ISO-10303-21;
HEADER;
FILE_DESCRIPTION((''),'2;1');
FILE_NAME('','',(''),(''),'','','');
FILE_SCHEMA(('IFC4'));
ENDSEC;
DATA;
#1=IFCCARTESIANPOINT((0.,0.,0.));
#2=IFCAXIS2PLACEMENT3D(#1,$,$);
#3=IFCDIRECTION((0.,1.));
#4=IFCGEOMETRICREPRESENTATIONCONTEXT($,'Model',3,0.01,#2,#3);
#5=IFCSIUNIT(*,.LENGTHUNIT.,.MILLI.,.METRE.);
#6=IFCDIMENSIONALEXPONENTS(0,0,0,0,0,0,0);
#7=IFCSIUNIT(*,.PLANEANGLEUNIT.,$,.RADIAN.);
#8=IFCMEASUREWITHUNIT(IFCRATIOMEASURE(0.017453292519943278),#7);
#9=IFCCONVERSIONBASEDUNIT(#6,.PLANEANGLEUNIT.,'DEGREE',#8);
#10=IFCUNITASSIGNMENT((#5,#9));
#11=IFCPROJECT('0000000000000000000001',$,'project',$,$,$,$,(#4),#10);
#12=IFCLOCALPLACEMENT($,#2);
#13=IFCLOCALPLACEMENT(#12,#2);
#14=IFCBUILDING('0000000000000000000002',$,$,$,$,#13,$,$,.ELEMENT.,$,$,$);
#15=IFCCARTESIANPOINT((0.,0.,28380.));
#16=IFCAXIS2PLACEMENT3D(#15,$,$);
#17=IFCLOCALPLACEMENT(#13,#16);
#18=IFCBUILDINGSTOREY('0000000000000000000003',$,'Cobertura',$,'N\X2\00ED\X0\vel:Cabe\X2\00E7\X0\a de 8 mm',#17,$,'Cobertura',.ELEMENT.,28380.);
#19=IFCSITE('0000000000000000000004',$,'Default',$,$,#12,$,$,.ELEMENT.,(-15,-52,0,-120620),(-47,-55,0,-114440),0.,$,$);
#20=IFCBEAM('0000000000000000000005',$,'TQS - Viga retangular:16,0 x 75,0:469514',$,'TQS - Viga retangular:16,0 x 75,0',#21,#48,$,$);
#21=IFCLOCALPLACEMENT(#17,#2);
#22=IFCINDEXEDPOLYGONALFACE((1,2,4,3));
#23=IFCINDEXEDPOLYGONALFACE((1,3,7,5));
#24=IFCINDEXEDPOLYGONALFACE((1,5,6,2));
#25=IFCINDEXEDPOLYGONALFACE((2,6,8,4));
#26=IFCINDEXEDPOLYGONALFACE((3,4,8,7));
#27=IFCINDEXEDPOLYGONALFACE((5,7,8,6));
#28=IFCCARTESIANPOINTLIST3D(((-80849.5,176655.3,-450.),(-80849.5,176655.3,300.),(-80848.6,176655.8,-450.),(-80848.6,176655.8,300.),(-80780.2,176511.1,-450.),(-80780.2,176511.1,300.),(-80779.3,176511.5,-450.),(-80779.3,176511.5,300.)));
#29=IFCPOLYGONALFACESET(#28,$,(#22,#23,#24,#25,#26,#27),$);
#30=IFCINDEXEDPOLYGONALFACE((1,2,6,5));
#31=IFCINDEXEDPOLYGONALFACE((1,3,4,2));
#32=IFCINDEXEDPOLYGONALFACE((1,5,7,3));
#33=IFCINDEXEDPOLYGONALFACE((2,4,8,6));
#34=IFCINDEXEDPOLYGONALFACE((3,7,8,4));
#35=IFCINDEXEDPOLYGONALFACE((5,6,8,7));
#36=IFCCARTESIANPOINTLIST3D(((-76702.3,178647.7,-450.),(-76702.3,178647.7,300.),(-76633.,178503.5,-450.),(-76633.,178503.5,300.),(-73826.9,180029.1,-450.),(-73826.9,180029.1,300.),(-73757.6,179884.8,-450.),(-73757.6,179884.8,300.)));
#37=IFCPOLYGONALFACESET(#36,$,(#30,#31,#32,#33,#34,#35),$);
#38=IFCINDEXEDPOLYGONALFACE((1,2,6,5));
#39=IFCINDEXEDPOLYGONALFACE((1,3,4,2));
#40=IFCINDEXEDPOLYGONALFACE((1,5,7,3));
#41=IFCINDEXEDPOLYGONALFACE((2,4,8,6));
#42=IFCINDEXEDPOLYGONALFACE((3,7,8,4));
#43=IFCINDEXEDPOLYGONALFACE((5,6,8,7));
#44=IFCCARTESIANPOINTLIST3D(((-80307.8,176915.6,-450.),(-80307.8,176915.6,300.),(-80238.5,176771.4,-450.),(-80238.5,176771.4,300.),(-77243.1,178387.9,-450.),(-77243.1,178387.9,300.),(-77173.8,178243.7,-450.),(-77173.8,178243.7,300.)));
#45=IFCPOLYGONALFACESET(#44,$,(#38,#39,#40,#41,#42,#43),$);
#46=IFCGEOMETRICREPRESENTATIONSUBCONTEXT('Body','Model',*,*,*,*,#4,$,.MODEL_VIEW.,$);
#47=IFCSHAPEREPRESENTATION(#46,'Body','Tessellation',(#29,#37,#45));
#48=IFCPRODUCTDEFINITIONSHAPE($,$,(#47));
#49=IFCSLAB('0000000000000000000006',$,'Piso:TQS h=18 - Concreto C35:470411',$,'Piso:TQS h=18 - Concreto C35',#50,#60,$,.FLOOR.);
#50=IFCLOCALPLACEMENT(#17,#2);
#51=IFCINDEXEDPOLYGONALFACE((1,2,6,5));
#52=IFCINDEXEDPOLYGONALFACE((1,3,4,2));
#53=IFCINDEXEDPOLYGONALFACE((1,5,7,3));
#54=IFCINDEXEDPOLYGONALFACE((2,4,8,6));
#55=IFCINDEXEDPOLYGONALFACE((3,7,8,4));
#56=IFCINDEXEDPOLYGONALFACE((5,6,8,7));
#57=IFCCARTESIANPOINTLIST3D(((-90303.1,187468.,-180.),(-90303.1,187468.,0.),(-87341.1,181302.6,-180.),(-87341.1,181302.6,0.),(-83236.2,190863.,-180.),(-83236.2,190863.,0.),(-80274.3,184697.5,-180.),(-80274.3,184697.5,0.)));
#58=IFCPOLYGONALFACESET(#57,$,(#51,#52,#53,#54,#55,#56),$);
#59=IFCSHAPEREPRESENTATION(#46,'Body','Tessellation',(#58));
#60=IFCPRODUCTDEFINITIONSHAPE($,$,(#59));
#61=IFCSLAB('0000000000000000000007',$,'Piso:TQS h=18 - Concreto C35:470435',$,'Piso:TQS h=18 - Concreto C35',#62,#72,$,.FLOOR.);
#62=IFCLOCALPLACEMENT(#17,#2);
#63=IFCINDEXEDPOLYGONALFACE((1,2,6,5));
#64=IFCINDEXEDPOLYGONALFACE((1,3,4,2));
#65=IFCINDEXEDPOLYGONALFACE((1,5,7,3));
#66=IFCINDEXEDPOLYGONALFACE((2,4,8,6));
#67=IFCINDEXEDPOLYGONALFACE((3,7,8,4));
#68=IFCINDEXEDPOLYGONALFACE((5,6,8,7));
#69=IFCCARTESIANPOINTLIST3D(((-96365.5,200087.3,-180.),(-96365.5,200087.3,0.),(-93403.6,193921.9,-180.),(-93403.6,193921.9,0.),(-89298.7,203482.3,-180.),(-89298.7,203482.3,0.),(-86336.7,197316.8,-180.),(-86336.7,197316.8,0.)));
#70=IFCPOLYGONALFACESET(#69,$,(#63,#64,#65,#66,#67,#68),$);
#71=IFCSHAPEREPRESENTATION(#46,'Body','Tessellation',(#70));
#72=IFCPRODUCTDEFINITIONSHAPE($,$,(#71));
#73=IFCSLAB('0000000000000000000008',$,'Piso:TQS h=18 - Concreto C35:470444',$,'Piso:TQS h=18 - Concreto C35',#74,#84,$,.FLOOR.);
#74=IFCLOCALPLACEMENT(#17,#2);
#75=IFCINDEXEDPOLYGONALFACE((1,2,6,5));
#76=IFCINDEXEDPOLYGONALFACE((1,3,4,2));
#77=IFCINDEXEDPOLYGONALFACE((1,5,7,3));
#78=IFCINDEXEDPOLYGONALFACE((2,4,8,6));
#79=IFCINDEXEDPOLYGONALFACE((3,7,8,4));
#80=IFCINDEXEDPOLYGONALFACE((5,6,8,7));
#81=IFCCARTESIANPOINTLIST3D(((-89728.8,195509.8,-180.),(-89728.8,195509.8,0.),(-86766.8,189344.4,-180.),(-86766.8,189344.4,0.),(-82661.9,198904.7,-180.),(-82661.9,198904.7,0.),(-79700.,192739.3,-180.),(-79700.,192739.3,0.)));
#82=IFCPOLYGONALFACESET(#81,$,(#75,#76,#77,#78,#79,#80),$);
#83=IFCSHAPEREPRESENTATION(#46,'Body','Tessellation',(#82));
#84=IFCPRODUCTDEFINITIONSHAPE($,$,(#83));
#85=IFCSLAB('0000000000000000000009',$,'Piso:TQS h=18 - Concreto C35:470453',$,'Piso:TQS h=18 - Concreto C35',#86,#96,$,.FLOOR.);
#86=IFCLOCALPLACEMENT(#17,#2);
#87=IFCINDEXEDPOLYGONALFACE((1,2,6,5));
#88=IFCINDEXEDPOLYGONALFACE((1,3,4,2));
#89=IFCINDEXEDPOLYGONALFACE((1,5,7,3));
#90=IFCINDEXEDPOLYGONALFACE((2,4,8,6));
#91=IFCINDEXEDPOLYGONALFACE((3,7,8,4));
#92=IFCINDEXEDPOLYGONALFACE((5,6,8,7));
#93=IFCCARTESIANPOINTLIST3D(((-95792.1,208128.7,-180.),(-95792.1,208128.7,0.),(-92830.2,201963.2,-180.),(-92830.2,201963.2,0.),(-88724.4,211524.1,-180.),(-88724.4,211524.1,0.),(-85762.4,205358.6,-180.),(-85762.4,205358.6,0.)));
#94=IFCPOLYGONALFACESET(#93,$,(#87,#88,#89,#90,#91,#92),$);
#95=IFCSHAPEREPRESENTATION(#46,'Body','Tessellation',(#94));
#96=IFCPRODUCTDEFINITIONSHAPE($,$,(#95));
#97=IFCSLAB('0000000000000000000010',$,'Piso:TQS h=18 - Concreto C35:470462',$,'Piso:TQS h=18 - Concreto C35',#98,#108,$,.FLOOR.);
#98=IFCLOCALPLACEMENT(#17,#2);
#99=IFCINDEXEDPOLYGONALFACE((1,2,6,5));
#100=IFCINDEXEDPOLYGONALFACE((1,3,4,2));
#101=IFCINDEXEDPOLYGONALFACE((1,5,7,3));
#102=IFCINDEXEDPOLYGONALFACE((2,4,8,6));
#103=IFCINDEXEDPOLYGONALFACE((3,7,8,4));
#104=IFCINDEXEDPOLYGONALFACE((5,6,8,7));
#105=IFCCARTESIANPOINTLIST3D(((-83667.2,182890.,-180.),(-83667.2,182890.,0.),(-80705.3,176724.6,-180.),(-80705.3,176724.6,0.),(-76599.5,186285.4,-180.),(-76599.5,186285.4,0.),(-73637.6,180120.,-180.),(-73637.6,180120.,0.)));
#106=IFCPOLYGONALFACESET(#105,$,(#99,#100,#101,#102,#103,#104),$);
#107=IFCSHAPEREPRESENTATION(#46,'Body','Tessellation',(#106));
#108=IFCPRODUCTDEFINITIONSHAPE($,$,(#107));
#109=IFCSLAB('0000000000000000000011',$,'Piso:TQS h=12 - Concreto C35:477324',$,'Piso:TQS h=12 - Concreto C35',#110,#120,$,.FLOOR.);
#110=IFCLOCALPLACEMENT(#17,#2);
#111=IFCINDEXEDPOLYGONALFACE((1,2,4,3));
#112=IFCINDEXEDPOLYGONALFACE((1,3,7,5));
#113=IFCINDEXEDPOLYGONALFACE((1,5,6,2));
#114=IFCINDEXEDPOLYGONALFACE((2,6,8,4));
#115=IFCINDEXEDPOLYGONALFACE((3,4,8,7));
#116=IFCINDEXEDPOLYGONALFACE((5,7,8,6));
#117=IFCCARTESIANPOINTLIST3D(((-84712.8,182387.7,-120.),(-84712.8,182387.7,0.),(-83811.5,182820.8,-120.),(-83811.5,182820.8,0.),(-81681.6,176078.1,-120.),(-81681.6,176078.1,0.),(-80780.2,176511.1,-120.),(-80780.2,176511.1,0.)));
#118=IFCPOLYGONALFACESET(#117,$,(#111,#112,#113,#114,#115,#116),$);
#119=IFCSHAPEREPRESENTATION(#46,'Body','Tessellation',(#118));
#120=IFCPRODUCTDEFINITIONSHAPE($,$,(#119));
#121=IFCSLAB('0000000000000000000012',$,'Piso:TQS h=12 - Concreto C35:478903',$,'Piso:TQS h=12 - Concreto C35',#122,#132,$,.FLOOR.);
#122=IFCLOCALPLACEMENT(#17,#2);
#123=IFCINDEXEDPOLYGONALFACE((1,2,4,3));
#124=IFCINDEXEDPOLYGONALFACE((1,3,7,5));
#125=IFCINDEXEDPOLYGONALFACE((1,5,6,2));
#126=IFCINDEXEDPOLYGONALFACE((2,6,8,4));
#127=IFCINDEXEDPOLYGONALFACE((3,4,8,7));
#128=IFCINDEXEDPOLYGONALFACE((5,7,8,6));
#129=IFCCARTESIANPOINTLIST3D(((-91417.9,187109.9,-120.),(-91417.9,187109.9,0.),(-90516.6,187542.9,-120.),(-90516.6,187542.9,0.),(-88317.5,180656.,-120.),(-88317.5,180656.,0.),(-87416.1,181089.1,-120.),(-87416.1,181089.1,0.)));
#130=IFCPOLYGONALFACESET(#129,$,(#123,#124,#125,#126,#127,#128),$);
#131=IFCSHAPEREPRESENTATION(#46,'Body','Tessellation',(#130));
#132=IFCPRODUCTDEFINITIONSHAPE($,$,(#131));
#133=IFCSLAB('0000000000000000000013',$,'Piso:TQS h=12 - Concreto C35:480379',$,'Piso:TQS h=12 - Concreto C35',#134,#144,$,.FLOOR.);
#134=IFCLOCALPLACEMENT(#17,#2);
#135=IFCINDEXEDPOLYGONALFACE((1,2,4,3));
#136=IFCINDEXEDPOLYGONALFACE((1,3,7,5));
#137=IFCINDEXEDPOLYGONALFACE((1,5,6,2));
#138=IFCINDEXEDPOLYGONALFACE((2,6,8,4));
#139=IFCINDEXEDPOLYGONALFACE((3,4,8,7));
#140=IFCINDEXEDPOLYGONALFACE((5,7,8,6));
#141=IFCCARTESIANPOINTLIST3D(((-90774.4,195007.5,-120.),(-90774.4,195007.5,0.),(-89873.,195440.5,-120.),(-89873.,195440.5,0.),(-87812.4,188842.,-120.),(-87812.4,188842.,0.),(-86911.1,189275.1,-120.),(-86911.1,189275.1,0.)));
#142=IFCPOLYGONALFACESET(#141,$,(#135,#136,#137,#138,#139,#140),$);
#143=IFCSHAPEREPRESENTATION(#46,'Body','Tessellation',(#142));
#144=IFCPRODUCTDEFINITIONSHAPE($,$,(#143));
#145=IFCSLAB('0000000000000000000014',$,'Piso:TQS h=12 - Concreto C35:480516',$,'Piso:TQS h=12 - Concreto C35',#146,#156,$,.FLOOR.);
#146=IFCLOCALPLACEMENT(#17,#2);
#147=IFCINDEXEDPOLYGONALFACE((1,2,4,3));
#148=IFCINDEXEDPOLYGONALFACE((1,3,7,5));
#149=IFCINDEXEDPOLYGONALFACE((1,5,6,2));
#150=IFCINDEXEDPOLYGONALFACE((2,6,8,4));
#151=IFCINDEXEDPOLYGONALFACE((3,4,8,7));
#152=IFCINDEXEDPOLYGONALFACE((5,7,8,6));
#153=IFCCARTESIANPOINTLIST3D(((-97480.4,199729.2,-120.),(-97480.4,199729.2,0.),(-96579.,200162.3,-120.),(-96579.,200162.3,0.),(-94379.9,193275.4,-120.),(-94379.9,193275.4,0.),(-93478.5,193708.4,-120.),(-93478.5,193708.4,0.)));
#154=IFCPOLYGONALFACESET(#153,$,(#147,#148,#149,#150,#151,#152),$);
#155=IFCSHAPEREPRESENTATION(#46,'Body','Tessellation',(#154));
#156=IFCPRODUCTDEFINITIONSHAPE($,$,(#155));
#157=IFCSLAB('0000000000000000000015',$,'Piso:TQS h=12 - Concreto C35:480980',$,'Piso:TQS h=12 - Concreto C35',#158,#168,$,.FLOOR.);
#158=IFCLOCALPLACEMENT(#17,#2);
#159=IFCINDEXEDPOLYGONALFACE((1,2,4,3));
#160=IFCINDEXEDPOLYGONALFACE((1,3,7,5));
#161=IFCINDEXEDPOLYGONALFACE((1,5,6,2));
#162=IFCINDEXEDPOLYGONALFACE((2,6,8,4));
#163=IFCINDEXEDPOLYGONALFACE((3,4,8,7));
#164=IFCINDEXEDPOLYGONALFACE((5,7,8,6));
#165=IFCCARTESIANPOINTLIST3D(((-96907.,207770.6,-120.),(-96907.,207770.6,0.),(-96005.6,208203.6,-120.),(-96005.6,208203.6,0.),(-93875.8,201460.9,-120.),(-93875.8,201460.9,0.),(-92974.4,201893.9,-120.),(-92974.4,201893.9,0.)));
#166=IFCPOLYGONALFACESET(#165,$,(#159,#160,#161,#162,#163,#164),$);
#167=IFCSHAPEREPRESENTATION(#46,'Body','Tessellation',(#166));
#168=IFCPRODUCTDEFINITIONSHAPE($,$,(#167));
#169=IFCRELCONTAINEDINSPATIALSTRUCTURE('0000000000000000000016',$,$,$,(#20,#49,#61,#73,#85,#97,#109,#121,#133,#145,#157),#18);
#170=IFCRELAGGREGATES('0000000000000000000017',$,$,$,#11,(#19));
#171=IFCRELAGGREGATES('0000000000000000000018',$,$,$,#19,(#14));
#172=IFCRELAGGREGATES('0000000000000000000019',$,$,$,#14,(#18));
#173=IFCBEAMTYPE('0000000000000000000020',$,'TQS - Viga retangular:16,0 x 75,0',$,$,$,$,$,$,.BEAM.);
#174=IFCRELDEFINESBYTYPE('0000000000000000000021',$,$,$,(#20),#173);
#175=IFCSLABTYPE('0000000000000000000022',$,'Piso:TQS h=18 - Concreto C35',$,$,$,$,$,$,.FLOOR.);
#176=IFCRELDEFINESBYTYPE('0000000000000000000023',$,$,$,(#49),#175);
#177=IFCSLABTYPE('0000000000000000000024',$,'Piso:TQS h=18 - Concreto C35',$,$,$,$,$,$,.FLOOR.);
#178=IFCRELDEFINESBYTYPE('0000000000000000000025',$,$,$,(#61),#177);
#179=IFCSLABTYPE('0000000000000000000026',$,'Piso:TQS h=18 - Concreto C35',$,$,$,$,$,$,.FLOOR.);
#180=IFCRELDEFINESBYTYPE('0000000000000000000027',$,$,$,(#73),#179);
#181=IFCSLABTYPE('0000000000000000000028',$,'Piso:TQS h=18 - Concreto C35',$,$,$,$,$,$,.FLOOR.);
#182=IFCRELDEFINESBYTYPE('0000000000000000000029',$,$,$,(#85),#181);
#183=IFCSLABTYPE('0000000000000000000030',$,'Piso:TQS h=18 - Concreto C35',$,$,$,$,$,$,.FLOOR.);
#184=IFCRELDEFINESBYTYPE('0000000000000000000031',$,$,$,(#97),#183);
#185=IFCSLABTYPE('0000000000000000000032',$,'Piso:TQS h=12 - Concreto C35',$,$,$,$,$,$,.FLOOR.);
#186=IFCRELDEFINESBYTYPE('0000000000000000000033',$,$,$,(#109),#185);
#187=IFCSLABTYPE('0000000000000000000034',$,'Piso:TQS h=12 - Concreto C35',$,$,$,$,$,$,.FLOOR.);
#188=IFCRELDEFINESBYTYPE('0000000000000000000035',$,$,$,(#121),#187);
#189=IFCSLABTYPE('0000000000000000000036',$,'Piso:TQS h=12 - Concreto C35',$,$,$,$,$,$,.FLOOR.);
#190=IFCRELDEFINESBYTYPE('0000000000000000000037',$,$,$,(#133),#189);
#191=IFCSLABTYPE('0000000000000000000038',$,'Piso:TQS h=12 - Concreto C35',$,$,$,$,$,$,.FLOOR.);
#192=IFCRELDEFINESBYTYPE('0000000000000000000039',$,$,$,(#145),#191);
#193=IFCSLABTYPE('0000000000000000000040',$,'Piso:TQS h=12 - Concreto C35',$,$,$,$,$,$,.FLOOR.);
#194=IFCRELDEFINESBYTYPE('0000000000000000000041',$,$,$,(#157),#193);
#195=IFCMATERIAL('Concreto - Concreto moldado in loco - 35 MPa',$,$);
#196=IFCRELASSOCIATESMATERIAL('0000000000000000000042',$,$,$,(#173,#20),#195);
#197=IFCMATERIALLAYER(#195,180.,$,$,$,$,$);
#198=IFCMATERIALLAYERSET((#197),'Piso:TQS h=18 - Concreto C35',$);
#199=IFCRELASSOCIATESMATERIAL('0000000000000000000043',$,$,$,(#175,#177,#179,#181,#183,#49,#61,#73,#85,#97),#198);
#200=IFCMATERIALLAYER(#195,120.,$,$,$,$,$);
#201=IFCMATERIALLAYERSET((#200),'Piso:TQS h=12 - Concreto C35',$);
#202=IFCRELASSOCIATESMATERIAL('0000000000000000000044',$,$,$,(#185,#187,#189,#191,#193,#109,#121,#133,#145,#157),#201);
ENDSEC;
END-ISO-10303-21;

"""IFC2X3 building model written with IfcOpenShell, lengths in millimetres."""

from ifc_helpers import new_model, entity, si_unit, converted_unit, direction, frame, frame_2d, origin, place, context, subcontext, project, spatial, rectangle, extrude, source, transform, mapped, material, layer, layer_set, layer_usage, type_object, type_shapes, element, save


model = new_model("IFC2X3")

# Units and contexts
model_context = context("Model", 3, precision=0.01, world=origin(), true_north=direction((0.0, 1.0)))
body_context = subcontext(model_context, "Body", "Model", "MODEL_VIEW")
ifc_project = project(units=[si_unit("LENGTHUNIT", "METRE", prefix="MILLI"), converted_unit("PLANEANGLEUNIT", "DEGREE", entity("IfcRatioMeasure", 0.017453292519943278), si_unit("PLANEANGLEUNIT", "RADIAN"), dimensions=[0, 0, 0, 0, 0, 0, 0])], contexts=[model_context])

# Site, building, storey
site_placement = place(None, origin())
site = spatial("IfcSite", under=ifc_project, at=site_placement, Name="Default", CompositionType="ELEMENT", RefLatitude=(-15, -52, 0, -120620), RefLongitude=(-47, -55, 0, -114440), RefElevation=0.0)
building_placement = place(site_placement, origin())
building = spatial("IfcBuilding", under=site, at=building_placement, CompositionType="ELEMENT")
storey_placement = place(building_placement, frame((0.0, 0.0, 28380.0)))
storey = spatial("IfcBuildingStorey", under=building, at=storey_placement, Name="Cobertura", ObjectType="Nível:Cabeça de 8 mm", LongName="Cobertura", CompositionType="ELEMENT", Elevation=28380.0)

# Beam
ifc_material = material(Name="Concreto - Concreto moldado in loco - 35 MPa")
beam_type_1 = type_object("IfcBeamType", Name="TQS - Viga retangular:16,0 x 75,0", PredefinedType="BEAM", material=ifc_material)
shared_shape_1 = source(origin(), body_context, "Body", "SweptSolid", [
    extrude(rectangle(XDim=750.0, YDim=160.0, at=frame_2d((0.0, 0.0), x_axis=(1.0, 0.0))), frame((-80814.0, 176583.6, 28305.0), z_axis=(-0.90138, -0.43303, 0.0), x_axis=(0.0, 0.0, -1.0)), (0.0, 0.0, 1.0), 1.0),
    extrude(rectangle(XDim=750.0, YDim=160.0, at=frame_2d((0.0, 0.0), x_axis=(1.0, 0.0))), frame((-73792.2, 179956.9, 28305.0), z_axis=(-0.90138, -0.43303, 0.0), x_axis=(0.0, 0.0, -1.0)), (0.0, 0.0, 1.0), 3190.0),
    extrude(rectangle(XDim=750.0, YDim=160.0, at=frame_2d((0.0, 0.0), x_axis=(1.0, 0.0))), frame((-77208.5, 178315.8, 28305.0), z_axis=(-0.90138, -0.43303, 0.0), x_axis=(0.0, 0.0, -1.0)), (0.0, 0.0, 1.0), 3400.0),
])
type_shapes(beam_type_1, [shared_shape_1])
beam_1_placement = place(storey_placement, frame((0.0, 0.0, -28380.0)))
element("IfcBeam", 1, at=beam_1_placement, inside=storey, type_object=beam_type_1, material=ifc_material, Name="TQS - Viga retangular:16,0 x 75,0:469514", ObjectType="TQS - Viga retangular:16,0 x 75,0", context=body_context, shape_type="MappedRepresentation", body=[
    mapped(shared_shape_1, transform((0.0, 0.0, 0.0), scale=1.0)),
])

# Slabs
ifc_layer_1 = layer(ifc_material, 180.0)
ifc_layer_set_1 = layer_set([ifc_layer_1], Name="Piso:TQS h=18 - Concreto C35")
ifc_layer_usage_1 = layer_usage(ifc_layer_set_1, "AXIS3", "POSITIVE", 0.0)
slab_type_1 = type_object("IfcSlabType", Name="Piso:TQS h=18 - Concreto C35", PredefinedType="FLOOR", material=ifc_layer_set_1)
slab_1_placement = place(storey_placement, origin())
element("IfcSlab", 2, at=slab_1_placement, inside=storey, type_object=slab_type_1, material=ifc_layer_usage_1, Name="Piso:TQS h=18 - Concreto C35:470411", ObjectType="Piso:TQS h=18 - Concreto C35", PredefinedType="FLOOR", context=body_context, shape_type="SweptSolid", body=[
    extrude(rectangle(XDim=6840.0, YDim=7840.0, at=frame_2d((0.0, 0.0), x_axis=(1.0, 0.0))), frame((-85288.7, 186082.8, 0.0), z_axis=(0.0, 0.0, -1.0), x_axis=(0.43303, -0.90138, 0.0)), (0.0, 0.0, 1.0), 180.0),
])
ifc_layer_usage_2 = layer_usage(ifc_layer_set_1, "AXIS3", "POSITIVE", 0.0)
slab_type_2 = type_object("IfcSlabType", Name="Piso:TQS h=18 - Concreto C35", PredefinedType="FLOOR", material=ifc_layer_set_1)
slab_2_placement = place(storey_placement, origin())
element("IfcSlab", 3, at=slab_2_placement, inside=storey, type_object=slab_type_2, material=ifc_layer_usage_2, Name="Piso:TQS h=18 - Concreto C35:470435", ObjectType="Piso:TQS h=18 - Concreto C35", PredefinedType="FLOOR", context=body_context, shape_type="SweptSolid", body=[
    extrude(rectangle(XDim=6840.0, YDim=7840.0, at=frame_2d((0.0, 0.0), x_axis=(1.0, 0.0))), frame((-91351.1, 198702.1, 0.0), z_axis=(0.0, 0.0, -1.0), x_axis=(0.43303, -0.90138, 0.0)), (0.0, 0.0, 1.0), 180.0),
])
ifc_layer_usage_3 = layer_usage(ifc_layer_set_1, "AXIS3", "POSITIVE", 0.0)
slab_type_3 = type_object("IfcSlabType", Name="Piso:TQS h=18 - Concreto C35", PredefinedType="FLOOR", material=ifc_layer_set_1)
slab_3_placement = place(storey_placement, origin())
element("IfcSlab", 4, at=slab_3_placement, inside=storey, type_object=slab_type_3, material=ifc_layer_usage_3, Name="Piso:TQS h=18 - Concreto C35:470444", ObjectType="Piso:TQS h=18 - Concreto C35", PredefinedType="FLOOR", context=body_context, shape_type="SweptSolid", body=[
    extrude(rectangle(XDim=6840.0, YDim=7840.0, at=frame_2d((0.0, 0.0), x_axis=(1.0, 0.0))), frame((-84714.4, 194124.5, 0.0), z_axis=(0.0, 0.0, -1.0), x_axis=(0.43303, -0.90138, 0.0)), (0.0, 0.0, 1.0), 180.0),
])
ifc_layer_usage_4 = layer_usage(ifc_layer_set_1, "AXIS3", "POSITIVE", 0.0)
slab_type_4 = type_object("IfcSlabType", Name="Piso:TQS h=18 - Concreto C35", PredefinedType="FLOOR", material=ifc_layer_set_1)
slab_4_placement = place(storey_placement, origin())
element("IfcSlab", 5, at=slab_4_placement, inside=storey, type_object=slab_type_4, material=ifc_layer_usage_4, Name="Piso:TQS h=18 - Concreto C35:470453", ObjectType="Piso:TQS h=18 - Concreto C35", PredefinedType="FLOOR", context=body_context, shape_type="SweptSolid", body=[
    extrude(rectangle(XDim=6840.0, YDim=7841.0, at=frame_2d((0.0, 0.0), x_axis=(1.0, 0.0))), frame((-90777.3, 206743.6, 0.0), z_axis=(0.0, 0.0, -1.0), x_axis=(0.43303, -0.90138, 0.0)), (0.0, 0.0, 1.0), 180.0),
])
ifc_layer_usage_5 = layer_usage(ifc_layer_set_1, "AXIS3", "POSITIVE", 0.0)
slab_type_5 = type_object("IfcSlabType", Name="Piso:TQS h=18 - Concreto C35", PredefinedType="FLOOR", material=ifc_layer_set_1)
slab_5_placement = place(storey_placement, origin())
element("IfcSlab", 6, at=slab_5_placement, inside=storey, type_object=slab_type_5, material=ifc_layer_usage_5, Name="Piso:TQS h=18 - Concreto C35:470462", ObjectType="Piso:TQS h=18 - Concreto C35", PredefinedType="FLOOR", context=body_context, shape_type="SweptSolid", body=[
    extrude(rectangle(XDim=6840.0, YDim=7841.0, at=frame_2d((0.0, 0.0), x_axis=(1.0, 0.0))), frame((-78652.4, 181505.0, 0.0), z_axis=(0.0, 0.0, -1.0), x_axis=(0.43303, -0.90138, 0.0)), (0.0, 0.0, 1.0), 180.0),
])
ifc_layer_2 = layer(ifc_material, 120.0)
ifc_layer_set_2 = layer_set([ifc_layer_2], Name="Piso:TQS h=12 - Concreto C35")
ifc_layer_usage_6 = layer_usage(ifc_layer_set_2, "AXIS3", "POSITIVE", 0.0)
slab_type_6 = type_object("IfcSlabType", Name="Piso:TQS h=12 - Concreto C35", PredefinedType="FLOOR", material=ifc_layer_set_2)
slab_6_placement = place(storey_placement, origin())
element("IfcSlab", 7, at=slab_6_placement, inside=storey, type_object=slab_type_6, material=ifc_layer_usage_6, Name="Piso:TQS h=12 - Concreto C35:477324", ObjectType="Piso:TQS h=12 - Concreto C35", PredefinedType="FLOOR", context=body_context, shape_type="SweptSolid", body=[
    extrude(rectangle(XDim=1000.0, YDim=7000.0, at=frame_2d((0.0, 0.0), x_axis=(1.0, 0.0))), frame((-82746.5, 179449.4, 0.0), z_axis=(0.0, 0.0, -1.0), x_axis=(0.90138, 0.43303, 0.0)), (0.0, 0.0, 1.0), 120.0),
])
ifc_layer_usage_7 = layer_usage(ifc_layer_set_2, "AXIS3", "POSITIVE", 0.0)
slab_type_7 = type_object("IfcSlabType", Name="Piso:TQS h=12 - Concreto C35", PredefinedType="FLOOR", material=ifc_layer_set_2)
slab_7_placement = place(storey_placement, origin())
element("IfcSlab", 8, at=slab_7_placement, inside=storey, type_object=slab_type_7, material=ifc_layer_usage_7, Name="Piso:TQS h=12 - Concreto C35:478903", ObjectType="Piso:TQS h=12 - Concreto C35", PredefinedType="FLOOR", context=body_context, shape_type="SweptSolid", body=[
    extrude(rectangle(XDim=7160.0, YDim=1000.0, at=frame_2d((0.0, 0.0), x_axis=(1.0, 0.0))), frame((-89417.0, 184099.5, 0.0), z_axis=(0.0, 0.0, -1.0), x_axis=(0.43303, -0.90138, 0.0)), (0.0, 0.0, 1.0), 120.0),
])
ifc_layer_usage_8 = layer_usage(ifc_layer_set_2, "AXIS3", "POSITIVE", 0.0)
slab_type_8 = type_object("IfcSlabType", Name="Piso:TQS h=12 - Concreto C35", PredefinedType="FLOOR", material=ifc_layer_set_2)
slab_8_placement = place(storey_placement, origin())
element("IfcSlab", 9, at=slab_8_placement, inside=storey, type_object=slab_type_8, material=ifc_layer_usage_8, Name="Piso:TQS h=12 - Concreto C35:480379", ObjectType="Piso:TQS h=12 - Concreto C35", PredefinedType="FLOOR", context=body_context, shape_type="SweptSolid", body=[
    extrude(rectangle(XDim=6840.0, YDim=1000.0, at=frame_2d((0.0, 0.0), x_axis=(1.0, 0.0))), frame((-88842.7, 192141.3, 0.0), z_axis=(0.0, 0.0, -1.0), x_axis=(0.43303, -0.90138, 0.0)), (0.0, 0.0, 1.0), 120.0),
])
ifc_layer_usage_9 = layer_usage(ifc_layer_set_2, "AXIS3", "POSITIVE", 0.0)
slab_type_9 = type_object("IfcSlabType", Name="Piso:TQS h=12 - Concreto C35", PredefinedType="FLOOR", material=ifc_layer_set_2)
slab_9_placement = place(storey_placement, origin())
element("IfcSlab", 10, at=slab_9_placement, inside=storey, type_object=slab_type_9, material=ifc_layer_usage_9, Name="Piso:TQS h=12 - Concreto C35:480516", ObjectType="Piso:TQS h=12 - Concreto C35", PredefinedType="FLOOR", context=body_context, shape_type="SweptSolid", body=[
    extrude(rectangle(XDim=7160.0, YDim=1000.0, at=frame_2d((0.0, 0.0), x_axis=(1.0, 0.0))), frame((-95479.4, 196718.8, 0.0), z_axis=(0.0, 0.0, -1.0), x_axis=(0.43303, -0.90138, 0.0)), (0.0, 0.0, 1.0), 120.0),
])
ifc_layer_usage_10 = layer_usage(ifc_layer_set_2, "AXIS3", "POSITIVE", 0.0)
slab_type_10 = type_object("IfcSlabType", Name="Piso:TQS h=12 - Concreto C35", PredefinedType="FLOOR", material=ifc_layer_set_2)
slab_10_placement = place(storey_placement, origin())
element("IfcSlab", 11, at=slab_10_placement, inside=storey, type_object=slab_type_10, material=ifc_layer_usage_10, Name="Piso:TQS h=12 - Concreto C35:480980", ObjectType="Piso:TQS h=12 - Concreto C35", PredefinedType="FLOOR", context=body_context, shape_type="SweptSolid", body=[
    extrude(rectangle(XDim=7000.0, YDim=1000.0, at=frame_2d((0.0, 0.0), x_axis=(1.0, 0.0))), frame((-94940.7, 204832.3, 0.0), z_axis=(0.0, 0.0, -1.0), x_axis=(0.43303, -0.90138, 0.0)), (0.0, 0.0, 1.0), 120.0),
])

save(model, "model.ifc")
